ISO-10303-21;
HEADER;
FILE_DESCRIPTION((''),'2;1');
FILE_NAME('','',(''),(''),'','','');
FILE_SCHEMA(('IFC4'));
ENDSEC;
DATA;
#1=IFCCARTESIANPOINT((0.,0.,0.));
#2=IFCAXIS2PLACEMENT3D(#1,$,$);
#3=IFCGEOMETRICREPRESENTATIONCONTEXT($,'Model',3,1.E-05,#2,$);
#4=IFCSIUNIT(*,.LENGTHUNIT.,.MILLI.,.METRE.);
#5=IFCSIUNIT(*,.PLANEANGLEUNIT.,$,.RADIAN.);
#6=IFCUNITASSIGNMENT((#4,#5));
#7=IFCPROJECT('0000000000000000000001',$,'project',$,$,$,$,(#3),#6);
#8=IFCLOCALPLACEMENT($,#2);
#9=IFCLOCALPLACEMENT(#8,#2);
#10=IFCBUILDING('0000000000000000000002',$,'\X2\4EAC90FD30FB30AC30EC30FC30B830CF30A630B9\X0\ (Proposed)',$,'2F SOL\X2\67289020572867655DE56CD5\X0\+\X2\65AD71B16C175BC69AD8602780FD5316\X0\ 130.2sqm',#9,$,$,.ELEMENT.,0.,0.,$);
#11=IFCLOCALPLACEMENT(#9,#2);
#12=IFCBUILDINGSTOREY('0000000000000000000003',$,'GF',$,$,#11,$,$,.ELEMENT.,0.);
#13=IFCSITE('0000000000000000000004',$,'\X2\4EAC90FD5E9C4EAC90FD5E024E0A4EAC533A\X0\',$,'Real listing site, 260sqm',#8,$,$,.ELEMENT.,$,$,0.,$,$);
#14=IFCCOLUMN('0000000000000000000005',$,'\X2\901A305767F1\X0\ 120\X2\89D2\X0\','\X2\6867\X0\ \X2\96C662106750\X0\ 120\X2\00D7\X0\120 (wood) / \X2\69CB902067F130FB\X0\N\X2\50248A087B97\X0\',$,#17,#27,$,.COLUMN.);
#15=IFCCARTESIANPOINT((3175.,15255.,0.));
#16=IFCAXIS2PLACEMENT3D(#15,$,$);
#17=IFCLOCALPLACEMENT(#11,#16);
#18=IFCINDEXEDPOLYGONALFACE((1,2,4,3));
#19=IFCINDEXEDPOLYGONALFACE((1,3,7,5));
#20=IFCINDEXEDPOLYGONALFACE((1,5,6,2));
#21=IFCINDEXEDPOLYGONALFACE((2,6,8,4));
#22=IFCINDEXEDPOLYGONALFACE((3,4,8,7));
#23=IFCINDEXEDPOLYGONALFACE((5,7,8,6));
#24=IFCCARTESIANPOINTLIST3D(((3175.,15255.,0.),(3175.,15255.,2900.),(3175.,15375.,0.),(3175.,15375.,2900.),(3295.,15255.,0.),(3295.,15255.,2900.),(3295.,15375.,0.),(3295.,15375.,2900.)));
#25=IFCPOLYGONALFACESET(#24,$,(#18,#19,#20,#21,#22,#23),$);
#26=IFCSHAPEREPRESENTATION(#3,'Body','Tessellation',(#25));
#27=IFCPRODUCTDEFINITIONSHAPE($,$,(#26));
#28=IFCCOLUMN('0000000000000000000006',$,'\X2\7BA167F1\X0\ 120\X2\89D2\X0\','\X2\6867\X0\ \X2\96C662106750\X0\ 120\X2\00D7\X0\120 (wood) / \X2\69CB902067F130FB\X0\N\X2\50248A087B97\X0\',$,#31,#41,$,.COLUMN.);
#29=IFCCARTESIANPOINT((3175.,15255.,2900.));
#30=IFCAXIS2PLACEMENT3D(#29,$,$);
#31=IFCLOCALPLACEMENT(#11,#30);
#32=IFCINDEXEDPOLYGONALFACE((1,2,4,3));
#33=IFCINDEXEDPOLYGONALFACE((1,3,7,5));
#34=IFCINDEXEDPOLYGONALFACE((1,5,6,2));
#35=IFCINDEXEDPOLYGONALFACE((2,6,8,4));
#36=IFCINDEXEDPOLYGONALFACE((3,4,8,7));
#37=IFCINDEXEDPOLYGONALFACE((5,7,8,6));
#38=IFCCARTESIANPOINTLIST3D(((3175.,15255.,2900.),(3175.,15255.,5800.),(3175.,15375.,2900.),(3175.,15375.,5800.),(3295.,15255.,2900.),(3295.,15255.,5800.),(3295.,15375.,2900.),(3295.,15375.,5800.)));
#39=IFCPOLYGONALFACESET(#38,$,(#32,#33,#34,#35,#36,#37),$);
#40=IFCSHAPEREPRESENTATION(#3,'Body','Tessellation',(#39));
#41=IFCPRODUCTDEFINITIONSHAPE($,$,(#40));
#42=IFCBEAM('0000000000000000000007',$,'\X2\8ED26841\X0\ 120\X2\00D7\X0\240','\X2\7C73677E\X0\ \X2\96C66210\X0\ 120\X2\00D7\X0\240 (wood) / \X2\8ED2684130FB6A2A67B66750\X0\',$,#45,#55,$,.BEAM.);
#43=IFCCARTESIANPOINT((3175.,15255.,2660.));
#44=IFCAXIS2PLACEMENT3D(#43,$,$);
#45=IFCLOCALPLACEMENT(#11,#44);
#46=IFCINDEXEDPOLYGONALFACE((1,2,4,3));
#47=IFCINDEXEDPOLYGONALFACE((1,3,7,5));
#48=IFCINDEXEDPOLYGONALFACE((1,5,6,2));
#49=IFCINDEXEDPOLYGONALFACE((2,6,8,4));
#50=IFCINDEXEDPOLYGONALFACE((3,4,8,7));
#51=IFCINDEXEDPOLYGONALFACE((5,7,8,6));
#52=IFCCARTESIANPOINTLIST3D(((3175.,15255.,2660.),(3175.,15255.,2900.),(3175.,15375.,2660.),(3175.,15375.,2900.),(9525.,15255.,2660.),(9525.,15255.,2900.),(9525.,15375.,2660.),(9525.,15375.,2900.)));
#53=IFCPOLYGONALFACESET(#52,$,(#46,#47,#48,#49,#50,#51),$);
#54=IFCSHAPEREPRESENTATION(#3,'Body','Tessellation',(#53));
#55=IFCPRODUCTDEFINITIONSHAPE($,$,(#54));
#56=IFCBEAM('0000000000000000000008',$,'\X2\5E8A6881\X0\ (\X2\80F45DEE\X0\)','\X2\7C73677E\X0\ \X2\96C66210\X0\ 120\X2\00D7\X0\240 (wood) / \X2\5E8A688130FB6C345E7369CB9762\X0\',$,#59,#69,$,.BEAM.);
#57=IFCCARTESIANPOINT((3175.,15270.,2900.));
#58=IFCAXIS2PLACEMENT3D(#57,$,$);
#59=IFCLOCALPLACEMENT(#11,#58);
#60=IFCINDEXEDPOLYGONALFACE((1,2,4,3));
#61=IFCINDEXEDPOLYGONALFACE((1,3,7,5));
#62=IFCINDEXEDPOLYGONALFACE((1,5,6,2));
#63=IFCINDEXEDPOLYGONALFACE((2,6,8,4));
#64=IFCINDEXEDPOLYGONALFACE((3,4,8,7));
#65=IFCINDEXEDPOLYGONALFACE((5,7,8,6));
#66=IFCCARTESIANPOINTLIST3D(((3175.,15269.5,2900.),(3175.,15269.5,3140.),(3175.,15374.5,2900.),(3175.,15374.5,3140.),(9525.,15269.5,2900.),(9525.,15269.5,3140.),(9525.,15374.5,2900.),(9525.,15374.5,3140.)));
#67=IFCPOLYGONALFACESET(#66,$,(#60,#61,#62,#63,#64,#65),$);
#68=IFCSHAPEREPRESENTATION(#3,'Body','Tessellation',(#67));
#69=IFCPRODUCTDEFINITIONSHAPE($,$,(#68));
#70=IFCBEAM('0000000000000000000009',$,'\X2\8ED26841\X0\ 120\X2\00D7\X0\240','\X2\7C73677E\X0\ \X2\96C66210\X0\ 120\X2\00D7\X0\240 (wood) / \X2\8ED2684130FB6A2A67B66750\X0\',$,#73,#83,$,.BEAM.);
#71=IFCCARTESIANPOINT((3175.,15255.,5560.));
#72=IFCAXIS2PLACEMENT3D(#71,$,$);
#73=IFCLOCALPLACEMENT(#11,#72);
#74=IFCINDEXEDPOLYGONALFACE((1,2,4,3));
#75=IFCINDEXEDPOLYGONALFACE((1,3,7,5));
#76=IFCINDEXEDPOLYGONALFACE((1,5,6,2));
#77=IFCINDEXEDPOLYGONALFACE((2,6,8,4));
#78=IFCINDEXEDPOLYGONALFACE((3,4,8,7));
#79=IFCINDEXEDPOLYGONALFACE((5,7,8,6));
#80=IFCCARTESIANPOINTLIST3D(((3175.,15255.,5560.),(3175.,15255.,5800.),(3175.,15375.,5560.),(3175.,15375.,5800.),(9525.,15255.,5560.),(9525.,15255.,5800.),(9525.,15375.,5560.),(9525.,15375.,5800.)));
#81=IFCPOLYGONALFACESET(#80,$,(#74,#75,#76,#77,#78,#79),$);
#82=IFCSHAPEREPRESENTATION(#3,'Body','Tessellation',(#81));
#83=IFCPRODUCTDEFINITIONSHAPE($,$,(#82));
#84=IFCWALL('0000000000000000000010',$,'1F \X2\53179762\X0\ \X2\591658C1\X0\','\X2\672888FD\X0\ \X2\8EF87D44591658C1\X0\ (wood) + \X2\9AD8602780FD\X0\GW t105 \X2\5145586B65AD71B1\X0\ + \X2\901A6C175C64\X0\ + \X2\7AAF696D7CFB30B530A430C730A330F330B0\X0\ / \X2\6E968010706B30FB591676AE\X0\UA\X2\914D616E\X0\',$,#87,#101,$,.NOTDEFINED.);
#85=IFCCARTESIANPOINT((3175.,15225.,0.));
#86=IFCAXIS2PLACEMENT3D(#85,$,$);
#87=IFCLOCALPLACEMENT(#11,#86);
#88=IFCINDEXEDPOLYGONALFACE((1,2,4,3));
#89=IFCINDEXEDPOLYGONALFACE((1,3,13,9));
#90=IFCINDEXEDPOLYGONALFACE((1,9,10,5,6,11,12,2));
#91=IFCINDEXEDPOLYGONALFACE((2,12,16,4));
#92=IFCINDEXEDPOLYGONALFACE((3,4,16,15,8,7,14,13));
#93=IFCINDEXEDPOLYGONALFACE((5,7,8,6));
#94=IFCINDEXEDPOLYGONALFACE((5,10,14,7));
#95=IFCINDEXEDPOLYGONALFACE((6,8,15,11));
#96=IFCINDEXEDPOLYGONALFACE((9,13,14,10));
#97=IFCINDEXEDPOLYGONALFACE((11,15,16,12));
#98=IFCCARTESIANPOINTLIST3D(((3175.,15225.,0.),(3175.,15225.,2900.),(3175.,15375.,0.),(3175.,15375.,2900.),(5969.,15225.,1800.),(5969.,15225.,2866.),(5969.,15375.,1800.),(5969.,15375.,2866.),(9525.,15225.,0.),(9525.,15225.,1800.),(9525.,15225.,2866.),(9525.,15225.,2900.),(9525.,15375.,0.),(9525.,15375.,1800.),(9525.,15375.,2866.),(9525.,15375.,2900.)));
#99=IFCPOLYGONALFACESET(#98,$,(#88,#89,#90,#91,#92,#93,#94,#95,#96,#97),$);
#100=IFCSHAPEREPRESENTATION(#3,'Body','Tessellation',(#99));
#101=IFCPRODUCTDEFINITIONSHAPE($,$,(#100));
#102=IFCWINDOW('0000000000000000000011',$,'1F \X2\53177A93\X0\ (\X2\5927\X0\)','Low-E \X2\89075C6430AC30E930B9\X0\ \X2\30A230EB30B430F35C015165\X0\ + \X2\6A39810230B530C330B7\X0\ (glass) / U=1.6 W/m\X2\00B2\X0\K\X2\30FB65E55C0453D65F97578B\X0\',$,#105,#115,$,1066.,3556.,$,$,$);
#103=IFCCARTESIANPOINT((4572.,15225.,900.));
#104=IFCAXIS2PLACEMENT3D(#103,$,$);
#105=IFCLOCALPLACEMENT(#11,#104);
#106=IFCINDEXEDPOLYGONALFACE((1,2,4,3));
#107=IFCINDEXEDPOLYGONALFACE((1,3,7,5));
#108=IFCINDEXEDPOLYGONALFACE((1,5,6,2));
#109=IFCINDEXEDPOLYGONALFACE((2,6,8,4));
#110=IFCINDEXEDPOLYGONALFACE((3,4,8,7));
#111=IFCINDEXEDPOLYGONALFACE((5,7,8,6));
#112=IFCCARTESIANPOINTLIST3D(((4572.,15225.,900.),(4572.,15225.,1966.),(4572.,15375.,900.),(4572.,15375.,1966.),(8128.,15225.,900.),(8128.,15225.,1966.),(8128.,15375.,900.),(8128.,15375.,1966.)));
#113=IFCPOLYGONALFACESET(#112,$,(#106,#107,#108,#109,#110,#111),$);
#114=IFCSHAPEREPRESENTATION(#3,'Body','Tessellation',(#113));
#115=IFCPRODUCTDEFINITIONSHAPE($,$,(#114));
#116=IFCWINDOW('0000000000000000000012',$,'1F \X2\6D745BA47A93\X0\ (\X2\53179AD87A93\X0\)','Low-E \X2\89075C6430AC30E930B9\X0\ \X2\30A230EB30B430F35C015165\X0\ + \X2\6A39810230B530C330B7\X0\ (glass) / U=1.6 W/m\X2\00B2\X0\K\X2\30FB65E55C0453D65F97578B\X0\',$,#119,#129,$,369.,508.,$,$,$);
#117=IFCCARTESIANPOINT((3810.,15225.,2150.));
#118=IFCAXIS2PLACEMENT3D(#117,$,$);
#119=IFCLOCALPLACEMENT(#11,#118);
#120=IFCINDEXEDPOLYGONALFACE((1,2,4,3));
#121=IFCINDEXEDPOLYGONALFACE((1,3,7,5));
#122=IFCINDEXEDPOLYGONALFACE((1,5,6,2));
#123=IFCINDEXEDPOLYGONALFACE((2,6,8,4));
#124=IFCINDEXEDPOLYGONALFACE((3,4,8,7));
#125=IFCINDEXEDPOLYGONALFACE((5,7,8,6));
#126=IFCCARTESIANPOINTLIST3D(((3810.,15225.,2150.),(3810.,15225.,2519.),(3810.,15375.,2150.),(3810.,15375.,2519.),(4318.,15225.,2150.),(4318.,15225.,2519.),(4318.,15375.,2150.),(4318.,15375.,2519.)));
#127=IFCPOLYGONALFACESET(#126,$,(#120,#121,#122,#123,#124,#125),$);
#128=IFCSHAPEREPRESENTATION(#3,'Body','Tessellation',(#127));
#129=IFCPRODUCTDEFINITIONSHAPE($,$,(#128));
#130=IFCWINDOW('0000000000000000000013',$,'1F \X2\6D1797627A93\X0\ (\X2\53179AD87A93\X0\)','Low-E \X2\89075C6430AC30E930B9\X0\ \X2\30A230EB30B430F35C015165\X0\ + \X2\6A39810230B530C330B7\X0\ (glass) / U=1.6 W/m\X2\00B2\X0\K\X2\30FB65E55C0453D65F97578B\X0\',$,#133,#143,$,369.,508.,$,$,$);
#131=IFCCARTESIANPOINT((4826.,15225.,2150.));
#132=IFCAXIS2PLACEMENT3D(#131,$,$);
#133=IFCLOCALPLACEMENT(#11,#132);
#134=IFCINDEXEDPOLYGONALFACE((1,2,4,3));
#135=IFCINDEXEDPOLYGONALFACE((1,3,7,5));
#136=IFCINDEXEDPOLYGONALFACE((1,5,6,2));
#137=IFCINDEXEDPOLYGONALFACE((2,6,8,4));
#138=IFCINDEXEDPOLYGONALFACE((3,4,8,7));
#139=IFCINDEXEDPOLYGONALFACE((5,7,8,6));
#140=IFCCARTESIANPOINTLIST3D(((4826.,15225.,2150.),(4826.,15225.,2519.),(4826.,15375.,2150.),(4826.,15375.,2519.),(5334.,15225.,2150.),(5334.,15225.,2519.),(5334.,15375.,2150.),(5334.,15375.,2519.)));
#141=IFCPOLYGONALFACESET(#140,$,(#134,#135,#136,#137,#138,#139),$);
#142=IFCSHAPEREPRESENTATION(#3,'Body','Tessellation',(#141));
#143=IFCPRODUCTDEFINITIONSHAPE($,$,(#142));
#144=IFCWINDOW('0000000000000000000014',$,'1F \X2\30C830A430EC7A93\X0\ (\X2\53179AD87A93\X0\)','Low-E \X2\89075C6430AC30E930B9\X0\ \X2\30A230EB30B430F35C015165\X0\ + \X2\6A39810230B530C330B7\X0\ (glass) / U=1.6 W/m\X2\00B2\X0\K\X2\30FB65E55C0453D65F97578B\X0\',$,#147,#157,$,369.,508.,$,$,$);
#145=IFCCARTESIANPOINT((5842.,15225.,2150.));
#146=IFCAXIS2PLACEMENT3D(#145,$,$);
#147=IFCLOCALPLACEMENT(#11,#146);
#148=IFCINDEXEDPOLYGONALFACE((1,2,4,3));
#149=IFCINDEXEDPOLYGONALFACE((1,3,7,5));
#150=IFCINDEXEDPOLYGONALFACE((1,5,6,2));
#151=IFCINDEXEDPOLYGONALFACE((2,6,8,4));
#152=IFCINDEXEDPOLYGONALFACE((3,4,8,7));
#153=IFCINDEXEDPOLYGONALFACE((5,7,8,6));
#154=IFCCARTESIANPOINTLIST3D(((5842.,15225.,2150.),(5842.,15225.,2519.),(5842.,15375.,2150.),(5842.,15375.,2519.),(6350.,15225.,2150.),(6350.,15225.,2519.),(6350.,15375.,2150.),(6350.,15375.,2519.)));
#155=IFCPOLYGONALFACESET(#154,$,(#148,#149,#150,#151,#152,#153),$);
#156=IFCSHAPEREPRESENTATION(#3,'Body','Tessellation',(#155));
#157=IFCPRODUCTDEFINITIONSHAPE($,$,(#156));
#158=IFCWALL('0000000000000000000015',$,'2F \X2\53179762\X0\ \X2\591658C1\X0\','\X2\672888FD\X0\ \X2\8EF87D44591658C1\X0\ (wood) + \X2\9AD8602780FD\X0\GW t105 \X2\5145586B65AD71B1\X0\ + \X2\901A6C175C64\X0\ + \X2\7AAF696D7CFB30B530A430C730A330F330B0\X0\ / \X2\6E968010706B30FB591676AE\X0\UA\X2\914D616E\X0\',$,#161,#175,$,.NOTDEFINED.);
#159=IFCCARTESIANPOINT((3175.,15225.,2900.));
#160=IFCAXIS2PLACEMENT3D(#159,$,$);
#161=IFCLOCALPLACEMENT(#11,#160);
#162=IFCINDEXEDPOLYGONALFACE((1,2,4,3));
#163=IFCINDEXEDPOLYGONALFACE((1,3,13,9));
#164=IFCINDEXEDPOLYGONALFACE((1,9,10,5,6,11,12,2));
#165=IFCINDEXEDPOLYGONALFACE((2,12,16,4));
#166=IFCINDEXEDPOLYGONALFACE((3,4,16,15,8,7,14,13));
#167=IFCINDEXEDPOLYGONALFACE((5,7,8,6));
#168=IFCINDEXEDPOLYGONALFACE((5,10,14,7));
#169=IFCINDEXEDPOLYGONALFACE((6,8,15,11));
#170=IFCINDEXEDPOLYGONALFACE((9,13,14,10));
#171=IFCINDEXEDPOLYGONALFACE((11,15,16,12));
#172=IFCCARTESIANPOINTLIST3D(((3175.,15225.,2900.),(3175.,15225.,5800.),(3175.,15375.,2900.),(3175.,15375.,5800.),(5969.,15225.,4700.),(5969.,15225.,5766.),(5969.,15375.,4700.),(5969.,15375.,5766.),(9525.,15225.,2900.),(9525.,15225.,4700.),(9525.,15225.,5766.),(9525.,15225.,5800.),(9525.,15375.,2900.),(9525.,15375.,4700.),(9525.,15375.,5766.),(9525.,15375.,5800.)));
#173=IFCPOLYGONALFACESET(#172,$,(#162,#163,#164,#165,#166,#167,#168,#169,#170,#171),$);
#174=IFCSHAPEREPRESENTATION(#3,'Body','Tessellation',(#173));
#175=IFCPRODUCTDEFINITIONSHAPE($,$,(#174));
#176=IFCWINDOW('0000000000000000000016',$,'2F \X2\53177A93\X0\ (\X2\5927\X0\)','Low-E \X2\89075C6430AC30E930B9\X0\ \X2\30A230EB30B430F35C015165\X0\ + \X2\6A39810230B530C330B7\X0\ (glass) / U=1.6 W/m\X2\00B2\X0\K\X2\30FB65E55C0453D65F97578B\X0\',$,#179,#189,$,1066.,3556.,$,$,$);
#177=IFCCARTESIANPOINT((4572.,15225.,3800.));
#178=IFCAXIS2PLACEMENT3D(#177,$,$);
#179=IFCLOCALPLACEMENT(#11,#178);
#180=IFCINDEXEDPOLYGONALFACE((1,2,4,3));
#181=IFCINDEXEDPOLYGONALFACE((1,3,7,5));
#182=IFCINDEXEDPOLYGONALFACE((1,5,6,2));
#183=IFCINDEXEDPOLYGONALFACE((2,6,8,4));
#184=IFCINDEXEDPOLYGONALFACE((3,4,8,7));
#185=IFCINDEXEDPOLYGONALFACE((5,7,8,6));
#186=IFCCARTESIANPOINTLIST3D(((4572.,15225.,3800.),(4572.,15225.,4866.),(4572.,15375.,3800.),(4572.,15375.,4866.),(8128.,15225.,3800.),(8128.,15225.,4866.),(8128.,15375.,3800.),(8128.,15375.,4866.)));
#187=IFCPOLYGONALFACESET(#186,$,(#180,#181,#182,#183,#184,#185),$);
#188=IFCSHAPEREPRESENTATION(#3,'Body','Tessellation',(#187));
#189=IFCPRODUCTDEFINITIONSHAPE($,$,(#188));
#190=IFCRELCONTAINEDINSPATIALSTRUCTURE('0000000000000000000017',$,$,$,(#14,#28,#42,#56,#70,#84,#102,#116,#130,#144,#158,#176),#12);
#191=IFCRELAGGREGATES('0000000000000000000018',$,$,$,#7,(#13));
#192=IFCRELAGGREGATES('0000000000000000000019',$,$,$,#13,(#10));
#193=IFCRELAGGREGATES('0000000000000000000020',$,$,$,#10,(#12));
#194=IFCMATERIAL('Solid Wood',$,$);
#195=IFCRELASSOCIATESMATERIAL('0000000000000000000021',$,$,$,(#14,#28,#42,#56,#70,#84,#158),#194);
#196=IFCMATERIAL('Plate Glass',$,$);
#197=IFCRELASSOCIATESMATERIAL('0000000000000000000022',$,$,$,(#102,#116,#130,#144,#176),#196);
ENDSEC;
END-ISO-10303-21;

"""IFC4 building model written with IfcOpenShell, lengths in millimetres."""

from ifc_helpers import new_model, si_unit, frame, frame_2d, origin, place, context, project, spatial, rectangle, extrude, material, element, fill, save


model = new_model("IFC4")

# Units and contexts
model_context = context("Model", 3, precision=1e-05, world=origin())
ifc_project = project(units=[si_unit("LENGTHUNIT", "METRE", prefix="MILLI"), si_unit("PLANEANGLEUNIT", "RADIAN")], contexts=[model_context])

# Site, building, storey
site_placement = place(None, origin())
site = spatial("IfcSite", under=ifc_project, at=site_placement, Name="京都府京都市上京区", ObjectType="Real listing site, 260sqm", CompositionType="ELEMENT", RefElevation=0.0)
building_placement = place(site_placement, origin())
building = spatial("IfcBuilding", under=site, at=building_placement, Name="京都・ガレージハウス (Proposed)", ObjectType="2F SOL木造在来工法+断熱気密高性能化 130.2sqm", CompositionType="ELEMENT", ElevationOfRefHeight=0.0, ElevationOfTerrain=0.0)
storey_placement = place(building_placement, origin())
storey = spatial("IfcBuildingStorey", under=building, at=storey_placement, Name="GF", CompositionType="ELEMENT", Elevation=0.0)

# Columns
ifc_material_1 = material(Name="Solid Wood")
column_1_placement = place(storey_placement, frame((3175.0, 15255.0, 0.0)))
element("IfcColumn", 1, at=column_1_placement, inside=storey, material=ifc_material_1, Name="通し柱 120角", Description="桧 集成材 120×120 (wood) / 構造柱・N値計算", PredefinedType="COLUMN", context=model_context, shape_type="SweptSolid", body=[
    extrude(rectangle(XDim=120.0, YDim=120.0, at=frame_2d((60.0, 60.0))), frame((3175.0, 15255.0, 0.0)), (0.0, 0.0, 1.0), 2900.0),
])
column_2_placement = place(storey_placement, frame((3175.0, 15255.0, 2900.0)))
element("IfcColumn", 2, at=column_2_placement, inside=storey, material=ifc_material_1, Name="管柱 120角", Description="桧 集成材 120×120 (wood) / 構造柱・N値計算", PredefinedType="COLUMN", context=model_context, shape_type="SweptSolid", body=[
    extrude(rectangle(XDim=120.0, YDim=120.0, at=frame_2d((60.0, 60.0))), frame((3175.0, 15255.0, 2900.0)), (0.0, 0.0, 1.0), 2900.0),
])

# Beams
beam_1_placement = place(storey_placement, frame((3175.0, 15255.0, 2660.0)))
element("IfcBeam", 3, at=beam_1_placement, inside=storey, material=ifc_material_1, Name="軒桁 120×240", Description="米松 集成 120×240 (wood) / 軒桁・横架材", PredefinedType="BEAM", context=model_context, shape_type="SweptSolid", body=[
    extrude(rectangle(XDim=6350.0, YDim=120.0, at=frame_2d((3175.0, 60.0))), frame((3175.0, 15255.0, 2660.0)), (0.0, 0.0, 1.0), 240.0),
])
beam_2_placement = place(storey_placement, frame((3175.0, 15270.0, 2900.0)))
element("IfcBeam", 4, at=beam_2_placement, inside=storey, material=ifc_material_1, Name="床梁 (胴差)", Description="米松 集成 120×240 (wood) / 床梁・水平構面", PredefinedType="BEAM", context=model_context, shape_type="SweptSolid", body=[
    extrude(rectangle(XDim=6350.0, YDim=105.0, at=frame_2d((3175.0, 52.0))), frame((3175.0, 15270.0, 2900.0)), (0.0, 0.0, 1.0), 240.0),
])
beam_3_placement = place(storey_placement, frame((3175.0, 15255.0, 5560.0)))
element("IfcBeam", 5, at=beam_3_placement, inside=storey, material=ifc_material_1, Name="軒桁 120×240", Description="米松 集成 120×240 (wood) / 軒桁・横架材", PredefinedType="BEAM", context=model_context, shape_type="SweptSolid", body=[
    extrude(rectangle(XDim=6350.0, YDim=120.0, at=frame_2d((3175.0, 60.0))), frame((3175.0, 15255.0, 5560.0)), (0.0, 0.0, 1.0), 240.0),
])

# Wall, openings, windows
wall_1_placement = place(storey_placement, frame((3175.0, 15225.0, 0.0)))
wall_1 = element("IfcWall", 6, at=wall_1_placement, inside=storey, material=ifc_material_1, Name="1F 北面 外壁", Description="木製 軸組外壁 (wood) + 高性能GW t105 充填断熱 + 通気層 + 窯業系サイディング / 準耐火・外皮UA配慮", PredefinedType="NOTDEFINED", context=model_context, shape_type="SweptSolid", body=[
    extrude(rectangle(XDim=6350.0, YDim=150.0, at=frame_2d((3175.0, 75.0))), frame((3175.0, 15225.0, 0.0)), (0.0, 0.0, 1.0), 2900.0),
])
opening_1_placement = place(storey_placement, frame((4572.0, 15225.0, 900.0)))
opening_1 = element("IfcOpeningElement", 7, at=opening_1_placement, cuts=wall_1, PredefinedType="NOTDEFINED", context=model_context, shape_type="SweptSolid", body=[
    extrude(rectangle(XDim=3556.0, YDim=150.0, at=frame_2d((1778.0, 75.0))), frame((4572.0, 15225.0, 900.0)), (0.0, 0.0, 1.0), 1066.0),
])
opening_2_placement = place(storey_placement, frame((3810.0, 15225.0, 2150.0)))
opening_2 = element("IfcOpeningElement", 8, at=opening_2_placement, cuts=wall_1, PredefinedType="NOTDEFINED", context=model_context, shape_type="SweptSolid", body=[
    extrude(rectangle(XDim=508.0, YDim=150.0, at=frame_2d((254.0, 75.0))), frame((3810.0, 15225.0, 2150.0)), (0.0, 0.0, 1.0), 369.0),
])
opening_3_placement = place(storey_placement, frame((4826.0, 15225.0, 2150.0)))
opening_3 = element("IfcOpeningElement", 9, at=opening_3_placement, cuts=wall_1, PredefinedType="NOTDEFINED", context=model_context, shape_type="SweptSolid", body=[
    extrude(rectangle(XDim=508.0, YDim=150.0, at=frame_2d((254.0, 75.0))), frame((4826.0, 15225.0, 2150.0)), (0.0, 0.0, 1.0), 369.0),
])
opening_4_placement = place(storey_placement, frame((5842.0, 15225.0, 2150.0)))
opening_4 = element("IfcOpeningElement", 10, at=opening_4_placement, cuts=wall_1, PredefinedType="NOTDEFINED", context=model_context, shape_type="SweptSolid", body=[
    extrude(rectangle(XDim=508.0, YDim=150.0, at=frame_2d((254.0, 75.0))), frame((5842.0, 15225.0, 2150.0)), (0.0, 0.0, 1.0), 369.0),
])
ifc_material_2 = material(Name="Plate Glass")
window_1_placement = place(storey_placement, frame((4572.0, 15225.0, 900.0)))
window_1 = element("IfcWindow", 11, at=window_1_placement, inside=storey, material=ifc_material_2, Name="1F 北窓 (大)", Description="Low-E 複層ガラス アルゴン封入 + 樹脂サッシ (glass) / U=1.6 W/m²K・日射取得型", OverallHeight=1066.0, OverallWidth=3556.0, context=model_context, shape_type="SweptSolid", body=[
    extrude(rectangle(XDim=3556.0, YDim=150.0, at=frame_2d((1778.0, 75.0))), frame((4572.0, 15225.0, 900.0)), (0.0, 0.0, 1.0), 1066.0),
])
fill(opening_1, window_1)
window_2_placement = place(storey_placement, frame((3810.0, 15225.0, 2150.0)))
window_2 = element("IfcWindow", 12, at=window_2_placement, inside=storey, material=ifc_material_2, Name="1F 浴室窓 (北高窓)", Description="Low-E 複層ガラス アルゴン封入 + 樹脂サッシ (glass) / U=1.6 W/m²K・日射取得型", OverallHeight=369.0, OverallWidth=508.0, context=model_context, shape_type="SweptSolid", body=[
    extrude(rectangle(XDim=508.0, YDim=150.0, at=frame_2d((254.0, 75.0))), frame((3810.0, 15225.0, 2150.0)), (0.0, 0.0, 1.0), 369.0),
])
fill(opening_2, window_2)
window_3_placement = place(storey_placement, frame((4826.0, 15225.0, 2150.0)))
window_3 = element("IfcWindow", 13, at=window_3_placement, inside=storey, material=ifc_material_2, Name="1F 洗面窓 (北高窓)", Description="Low-E 複層ガラス アルゴン封入 + 樹脂サッシ (glass) / U=1.6 W/m²K・日射取得型", OverallHeight=369.0, OverallWidth=508.0, context=model_context, shape_type="SweptSolid", body=[
    extrude(rectangle(XDim=508.0, YDim=150.0, at=frame_2d((254.0, 75.0))), frame((4826.0, 15225.0, 2150.0)), (0.0, 0.0, 1.0), 369.0),
])
fill(opening_3, window_3)
window_4_placement = place(storey_placement, frame((5842.0, 15225.0, 2150.0)))
window_4 = element("IfcWindow", 14, at=window_4_placement, inside=storey, material=ifc_material_2, Name="1F トイレ窓 (北高窓)", Description="Low-E 複層ガラス アルゴン封入 + 樹脂サッシ (glass) / U=1.6 W/m²K・日射取得型", OverallHeight=369.0, OverallWidth=508.0, context=model_context, shape_type="SweptSolid", body=[
    extrude(rectangle(XDim=508.0, YDim=150.0, at=frame_2d((254.0, 75.0))), frame((5842.0, 15225.0, 2150.0)), (0.0, 0.0, 1.0), 369.0),
])
fill(opening_4, window_4)

# Wall, opening, window
wall_2_placement = place(storey_placement, frame((3175.0, 15225.0, 2900.0)))
wall_2 = element("IfcWall", 15, at=wall_2_placement, inside=storey, material=ifc_material_1, Name="2F 北面 外壁", Description="木製 軸組外壁 (wood) + 高性能GW t105 充填断熱 + 通気層 + 窯業系サイディング / 準耐火・外皮UA配慮", PredefinedType="NOTDEFINED", context=model_context, shape_type="SweptSolid", body=[
    extrude(rectangle(XDim=6350.0, YDim=150.0, at=frame_2d((3175.0, 75.0))), frame((3175.0, 15225.0, 2900.0)), (0.0, 0.0, 1.0), 2900.0),
])
opening_5_placement = place(storey_placement, frame((4572.0, 15225.0, 3800.0)))
opening_5 = element("IfcOpeningElement", 16, at=opening_5_placement, cuts=wall_2, PredefinedType="NOTDEFINED", context=model_context, shape_type="SweptSolid", body=[
    extrude(rectangle(XDim=3556.0, YDim=150.0, at=frame_2d((1778.0, 75.0))), frame((4572.0, 15225.0, 3800.0)), (0.0, 0.0, 1.0), 1066.0),
])
window_5_placement = place(storey_placement, frame((4572.0, 15225.0, 3800.0)))
window_5 = element("IfcWindow", 17, at=window_5_placement, inside=storey, material=ifc_material_2, Name="2F 北窓 (大)", Description="Low-E 複層ガラス アルゴン封入 + 樹脂サッシ (glass) / U=1.6 W/m²K・日射取得型", OverallHeight=1066.0, OverallWidth=3556.0, context=model_context, shape_type="SweptSolid", body=[
    extrude(rectangle(XDim=3556.0, YDim=150.0, at=frame_2d((1778.0, 75.0))), frame((4572.0, 15225.0, 3800.0)), (0.0, 0.0, 1.0), 1066.0),
])
fill(opening_5, window_5)

save(model, "model.ifc")
